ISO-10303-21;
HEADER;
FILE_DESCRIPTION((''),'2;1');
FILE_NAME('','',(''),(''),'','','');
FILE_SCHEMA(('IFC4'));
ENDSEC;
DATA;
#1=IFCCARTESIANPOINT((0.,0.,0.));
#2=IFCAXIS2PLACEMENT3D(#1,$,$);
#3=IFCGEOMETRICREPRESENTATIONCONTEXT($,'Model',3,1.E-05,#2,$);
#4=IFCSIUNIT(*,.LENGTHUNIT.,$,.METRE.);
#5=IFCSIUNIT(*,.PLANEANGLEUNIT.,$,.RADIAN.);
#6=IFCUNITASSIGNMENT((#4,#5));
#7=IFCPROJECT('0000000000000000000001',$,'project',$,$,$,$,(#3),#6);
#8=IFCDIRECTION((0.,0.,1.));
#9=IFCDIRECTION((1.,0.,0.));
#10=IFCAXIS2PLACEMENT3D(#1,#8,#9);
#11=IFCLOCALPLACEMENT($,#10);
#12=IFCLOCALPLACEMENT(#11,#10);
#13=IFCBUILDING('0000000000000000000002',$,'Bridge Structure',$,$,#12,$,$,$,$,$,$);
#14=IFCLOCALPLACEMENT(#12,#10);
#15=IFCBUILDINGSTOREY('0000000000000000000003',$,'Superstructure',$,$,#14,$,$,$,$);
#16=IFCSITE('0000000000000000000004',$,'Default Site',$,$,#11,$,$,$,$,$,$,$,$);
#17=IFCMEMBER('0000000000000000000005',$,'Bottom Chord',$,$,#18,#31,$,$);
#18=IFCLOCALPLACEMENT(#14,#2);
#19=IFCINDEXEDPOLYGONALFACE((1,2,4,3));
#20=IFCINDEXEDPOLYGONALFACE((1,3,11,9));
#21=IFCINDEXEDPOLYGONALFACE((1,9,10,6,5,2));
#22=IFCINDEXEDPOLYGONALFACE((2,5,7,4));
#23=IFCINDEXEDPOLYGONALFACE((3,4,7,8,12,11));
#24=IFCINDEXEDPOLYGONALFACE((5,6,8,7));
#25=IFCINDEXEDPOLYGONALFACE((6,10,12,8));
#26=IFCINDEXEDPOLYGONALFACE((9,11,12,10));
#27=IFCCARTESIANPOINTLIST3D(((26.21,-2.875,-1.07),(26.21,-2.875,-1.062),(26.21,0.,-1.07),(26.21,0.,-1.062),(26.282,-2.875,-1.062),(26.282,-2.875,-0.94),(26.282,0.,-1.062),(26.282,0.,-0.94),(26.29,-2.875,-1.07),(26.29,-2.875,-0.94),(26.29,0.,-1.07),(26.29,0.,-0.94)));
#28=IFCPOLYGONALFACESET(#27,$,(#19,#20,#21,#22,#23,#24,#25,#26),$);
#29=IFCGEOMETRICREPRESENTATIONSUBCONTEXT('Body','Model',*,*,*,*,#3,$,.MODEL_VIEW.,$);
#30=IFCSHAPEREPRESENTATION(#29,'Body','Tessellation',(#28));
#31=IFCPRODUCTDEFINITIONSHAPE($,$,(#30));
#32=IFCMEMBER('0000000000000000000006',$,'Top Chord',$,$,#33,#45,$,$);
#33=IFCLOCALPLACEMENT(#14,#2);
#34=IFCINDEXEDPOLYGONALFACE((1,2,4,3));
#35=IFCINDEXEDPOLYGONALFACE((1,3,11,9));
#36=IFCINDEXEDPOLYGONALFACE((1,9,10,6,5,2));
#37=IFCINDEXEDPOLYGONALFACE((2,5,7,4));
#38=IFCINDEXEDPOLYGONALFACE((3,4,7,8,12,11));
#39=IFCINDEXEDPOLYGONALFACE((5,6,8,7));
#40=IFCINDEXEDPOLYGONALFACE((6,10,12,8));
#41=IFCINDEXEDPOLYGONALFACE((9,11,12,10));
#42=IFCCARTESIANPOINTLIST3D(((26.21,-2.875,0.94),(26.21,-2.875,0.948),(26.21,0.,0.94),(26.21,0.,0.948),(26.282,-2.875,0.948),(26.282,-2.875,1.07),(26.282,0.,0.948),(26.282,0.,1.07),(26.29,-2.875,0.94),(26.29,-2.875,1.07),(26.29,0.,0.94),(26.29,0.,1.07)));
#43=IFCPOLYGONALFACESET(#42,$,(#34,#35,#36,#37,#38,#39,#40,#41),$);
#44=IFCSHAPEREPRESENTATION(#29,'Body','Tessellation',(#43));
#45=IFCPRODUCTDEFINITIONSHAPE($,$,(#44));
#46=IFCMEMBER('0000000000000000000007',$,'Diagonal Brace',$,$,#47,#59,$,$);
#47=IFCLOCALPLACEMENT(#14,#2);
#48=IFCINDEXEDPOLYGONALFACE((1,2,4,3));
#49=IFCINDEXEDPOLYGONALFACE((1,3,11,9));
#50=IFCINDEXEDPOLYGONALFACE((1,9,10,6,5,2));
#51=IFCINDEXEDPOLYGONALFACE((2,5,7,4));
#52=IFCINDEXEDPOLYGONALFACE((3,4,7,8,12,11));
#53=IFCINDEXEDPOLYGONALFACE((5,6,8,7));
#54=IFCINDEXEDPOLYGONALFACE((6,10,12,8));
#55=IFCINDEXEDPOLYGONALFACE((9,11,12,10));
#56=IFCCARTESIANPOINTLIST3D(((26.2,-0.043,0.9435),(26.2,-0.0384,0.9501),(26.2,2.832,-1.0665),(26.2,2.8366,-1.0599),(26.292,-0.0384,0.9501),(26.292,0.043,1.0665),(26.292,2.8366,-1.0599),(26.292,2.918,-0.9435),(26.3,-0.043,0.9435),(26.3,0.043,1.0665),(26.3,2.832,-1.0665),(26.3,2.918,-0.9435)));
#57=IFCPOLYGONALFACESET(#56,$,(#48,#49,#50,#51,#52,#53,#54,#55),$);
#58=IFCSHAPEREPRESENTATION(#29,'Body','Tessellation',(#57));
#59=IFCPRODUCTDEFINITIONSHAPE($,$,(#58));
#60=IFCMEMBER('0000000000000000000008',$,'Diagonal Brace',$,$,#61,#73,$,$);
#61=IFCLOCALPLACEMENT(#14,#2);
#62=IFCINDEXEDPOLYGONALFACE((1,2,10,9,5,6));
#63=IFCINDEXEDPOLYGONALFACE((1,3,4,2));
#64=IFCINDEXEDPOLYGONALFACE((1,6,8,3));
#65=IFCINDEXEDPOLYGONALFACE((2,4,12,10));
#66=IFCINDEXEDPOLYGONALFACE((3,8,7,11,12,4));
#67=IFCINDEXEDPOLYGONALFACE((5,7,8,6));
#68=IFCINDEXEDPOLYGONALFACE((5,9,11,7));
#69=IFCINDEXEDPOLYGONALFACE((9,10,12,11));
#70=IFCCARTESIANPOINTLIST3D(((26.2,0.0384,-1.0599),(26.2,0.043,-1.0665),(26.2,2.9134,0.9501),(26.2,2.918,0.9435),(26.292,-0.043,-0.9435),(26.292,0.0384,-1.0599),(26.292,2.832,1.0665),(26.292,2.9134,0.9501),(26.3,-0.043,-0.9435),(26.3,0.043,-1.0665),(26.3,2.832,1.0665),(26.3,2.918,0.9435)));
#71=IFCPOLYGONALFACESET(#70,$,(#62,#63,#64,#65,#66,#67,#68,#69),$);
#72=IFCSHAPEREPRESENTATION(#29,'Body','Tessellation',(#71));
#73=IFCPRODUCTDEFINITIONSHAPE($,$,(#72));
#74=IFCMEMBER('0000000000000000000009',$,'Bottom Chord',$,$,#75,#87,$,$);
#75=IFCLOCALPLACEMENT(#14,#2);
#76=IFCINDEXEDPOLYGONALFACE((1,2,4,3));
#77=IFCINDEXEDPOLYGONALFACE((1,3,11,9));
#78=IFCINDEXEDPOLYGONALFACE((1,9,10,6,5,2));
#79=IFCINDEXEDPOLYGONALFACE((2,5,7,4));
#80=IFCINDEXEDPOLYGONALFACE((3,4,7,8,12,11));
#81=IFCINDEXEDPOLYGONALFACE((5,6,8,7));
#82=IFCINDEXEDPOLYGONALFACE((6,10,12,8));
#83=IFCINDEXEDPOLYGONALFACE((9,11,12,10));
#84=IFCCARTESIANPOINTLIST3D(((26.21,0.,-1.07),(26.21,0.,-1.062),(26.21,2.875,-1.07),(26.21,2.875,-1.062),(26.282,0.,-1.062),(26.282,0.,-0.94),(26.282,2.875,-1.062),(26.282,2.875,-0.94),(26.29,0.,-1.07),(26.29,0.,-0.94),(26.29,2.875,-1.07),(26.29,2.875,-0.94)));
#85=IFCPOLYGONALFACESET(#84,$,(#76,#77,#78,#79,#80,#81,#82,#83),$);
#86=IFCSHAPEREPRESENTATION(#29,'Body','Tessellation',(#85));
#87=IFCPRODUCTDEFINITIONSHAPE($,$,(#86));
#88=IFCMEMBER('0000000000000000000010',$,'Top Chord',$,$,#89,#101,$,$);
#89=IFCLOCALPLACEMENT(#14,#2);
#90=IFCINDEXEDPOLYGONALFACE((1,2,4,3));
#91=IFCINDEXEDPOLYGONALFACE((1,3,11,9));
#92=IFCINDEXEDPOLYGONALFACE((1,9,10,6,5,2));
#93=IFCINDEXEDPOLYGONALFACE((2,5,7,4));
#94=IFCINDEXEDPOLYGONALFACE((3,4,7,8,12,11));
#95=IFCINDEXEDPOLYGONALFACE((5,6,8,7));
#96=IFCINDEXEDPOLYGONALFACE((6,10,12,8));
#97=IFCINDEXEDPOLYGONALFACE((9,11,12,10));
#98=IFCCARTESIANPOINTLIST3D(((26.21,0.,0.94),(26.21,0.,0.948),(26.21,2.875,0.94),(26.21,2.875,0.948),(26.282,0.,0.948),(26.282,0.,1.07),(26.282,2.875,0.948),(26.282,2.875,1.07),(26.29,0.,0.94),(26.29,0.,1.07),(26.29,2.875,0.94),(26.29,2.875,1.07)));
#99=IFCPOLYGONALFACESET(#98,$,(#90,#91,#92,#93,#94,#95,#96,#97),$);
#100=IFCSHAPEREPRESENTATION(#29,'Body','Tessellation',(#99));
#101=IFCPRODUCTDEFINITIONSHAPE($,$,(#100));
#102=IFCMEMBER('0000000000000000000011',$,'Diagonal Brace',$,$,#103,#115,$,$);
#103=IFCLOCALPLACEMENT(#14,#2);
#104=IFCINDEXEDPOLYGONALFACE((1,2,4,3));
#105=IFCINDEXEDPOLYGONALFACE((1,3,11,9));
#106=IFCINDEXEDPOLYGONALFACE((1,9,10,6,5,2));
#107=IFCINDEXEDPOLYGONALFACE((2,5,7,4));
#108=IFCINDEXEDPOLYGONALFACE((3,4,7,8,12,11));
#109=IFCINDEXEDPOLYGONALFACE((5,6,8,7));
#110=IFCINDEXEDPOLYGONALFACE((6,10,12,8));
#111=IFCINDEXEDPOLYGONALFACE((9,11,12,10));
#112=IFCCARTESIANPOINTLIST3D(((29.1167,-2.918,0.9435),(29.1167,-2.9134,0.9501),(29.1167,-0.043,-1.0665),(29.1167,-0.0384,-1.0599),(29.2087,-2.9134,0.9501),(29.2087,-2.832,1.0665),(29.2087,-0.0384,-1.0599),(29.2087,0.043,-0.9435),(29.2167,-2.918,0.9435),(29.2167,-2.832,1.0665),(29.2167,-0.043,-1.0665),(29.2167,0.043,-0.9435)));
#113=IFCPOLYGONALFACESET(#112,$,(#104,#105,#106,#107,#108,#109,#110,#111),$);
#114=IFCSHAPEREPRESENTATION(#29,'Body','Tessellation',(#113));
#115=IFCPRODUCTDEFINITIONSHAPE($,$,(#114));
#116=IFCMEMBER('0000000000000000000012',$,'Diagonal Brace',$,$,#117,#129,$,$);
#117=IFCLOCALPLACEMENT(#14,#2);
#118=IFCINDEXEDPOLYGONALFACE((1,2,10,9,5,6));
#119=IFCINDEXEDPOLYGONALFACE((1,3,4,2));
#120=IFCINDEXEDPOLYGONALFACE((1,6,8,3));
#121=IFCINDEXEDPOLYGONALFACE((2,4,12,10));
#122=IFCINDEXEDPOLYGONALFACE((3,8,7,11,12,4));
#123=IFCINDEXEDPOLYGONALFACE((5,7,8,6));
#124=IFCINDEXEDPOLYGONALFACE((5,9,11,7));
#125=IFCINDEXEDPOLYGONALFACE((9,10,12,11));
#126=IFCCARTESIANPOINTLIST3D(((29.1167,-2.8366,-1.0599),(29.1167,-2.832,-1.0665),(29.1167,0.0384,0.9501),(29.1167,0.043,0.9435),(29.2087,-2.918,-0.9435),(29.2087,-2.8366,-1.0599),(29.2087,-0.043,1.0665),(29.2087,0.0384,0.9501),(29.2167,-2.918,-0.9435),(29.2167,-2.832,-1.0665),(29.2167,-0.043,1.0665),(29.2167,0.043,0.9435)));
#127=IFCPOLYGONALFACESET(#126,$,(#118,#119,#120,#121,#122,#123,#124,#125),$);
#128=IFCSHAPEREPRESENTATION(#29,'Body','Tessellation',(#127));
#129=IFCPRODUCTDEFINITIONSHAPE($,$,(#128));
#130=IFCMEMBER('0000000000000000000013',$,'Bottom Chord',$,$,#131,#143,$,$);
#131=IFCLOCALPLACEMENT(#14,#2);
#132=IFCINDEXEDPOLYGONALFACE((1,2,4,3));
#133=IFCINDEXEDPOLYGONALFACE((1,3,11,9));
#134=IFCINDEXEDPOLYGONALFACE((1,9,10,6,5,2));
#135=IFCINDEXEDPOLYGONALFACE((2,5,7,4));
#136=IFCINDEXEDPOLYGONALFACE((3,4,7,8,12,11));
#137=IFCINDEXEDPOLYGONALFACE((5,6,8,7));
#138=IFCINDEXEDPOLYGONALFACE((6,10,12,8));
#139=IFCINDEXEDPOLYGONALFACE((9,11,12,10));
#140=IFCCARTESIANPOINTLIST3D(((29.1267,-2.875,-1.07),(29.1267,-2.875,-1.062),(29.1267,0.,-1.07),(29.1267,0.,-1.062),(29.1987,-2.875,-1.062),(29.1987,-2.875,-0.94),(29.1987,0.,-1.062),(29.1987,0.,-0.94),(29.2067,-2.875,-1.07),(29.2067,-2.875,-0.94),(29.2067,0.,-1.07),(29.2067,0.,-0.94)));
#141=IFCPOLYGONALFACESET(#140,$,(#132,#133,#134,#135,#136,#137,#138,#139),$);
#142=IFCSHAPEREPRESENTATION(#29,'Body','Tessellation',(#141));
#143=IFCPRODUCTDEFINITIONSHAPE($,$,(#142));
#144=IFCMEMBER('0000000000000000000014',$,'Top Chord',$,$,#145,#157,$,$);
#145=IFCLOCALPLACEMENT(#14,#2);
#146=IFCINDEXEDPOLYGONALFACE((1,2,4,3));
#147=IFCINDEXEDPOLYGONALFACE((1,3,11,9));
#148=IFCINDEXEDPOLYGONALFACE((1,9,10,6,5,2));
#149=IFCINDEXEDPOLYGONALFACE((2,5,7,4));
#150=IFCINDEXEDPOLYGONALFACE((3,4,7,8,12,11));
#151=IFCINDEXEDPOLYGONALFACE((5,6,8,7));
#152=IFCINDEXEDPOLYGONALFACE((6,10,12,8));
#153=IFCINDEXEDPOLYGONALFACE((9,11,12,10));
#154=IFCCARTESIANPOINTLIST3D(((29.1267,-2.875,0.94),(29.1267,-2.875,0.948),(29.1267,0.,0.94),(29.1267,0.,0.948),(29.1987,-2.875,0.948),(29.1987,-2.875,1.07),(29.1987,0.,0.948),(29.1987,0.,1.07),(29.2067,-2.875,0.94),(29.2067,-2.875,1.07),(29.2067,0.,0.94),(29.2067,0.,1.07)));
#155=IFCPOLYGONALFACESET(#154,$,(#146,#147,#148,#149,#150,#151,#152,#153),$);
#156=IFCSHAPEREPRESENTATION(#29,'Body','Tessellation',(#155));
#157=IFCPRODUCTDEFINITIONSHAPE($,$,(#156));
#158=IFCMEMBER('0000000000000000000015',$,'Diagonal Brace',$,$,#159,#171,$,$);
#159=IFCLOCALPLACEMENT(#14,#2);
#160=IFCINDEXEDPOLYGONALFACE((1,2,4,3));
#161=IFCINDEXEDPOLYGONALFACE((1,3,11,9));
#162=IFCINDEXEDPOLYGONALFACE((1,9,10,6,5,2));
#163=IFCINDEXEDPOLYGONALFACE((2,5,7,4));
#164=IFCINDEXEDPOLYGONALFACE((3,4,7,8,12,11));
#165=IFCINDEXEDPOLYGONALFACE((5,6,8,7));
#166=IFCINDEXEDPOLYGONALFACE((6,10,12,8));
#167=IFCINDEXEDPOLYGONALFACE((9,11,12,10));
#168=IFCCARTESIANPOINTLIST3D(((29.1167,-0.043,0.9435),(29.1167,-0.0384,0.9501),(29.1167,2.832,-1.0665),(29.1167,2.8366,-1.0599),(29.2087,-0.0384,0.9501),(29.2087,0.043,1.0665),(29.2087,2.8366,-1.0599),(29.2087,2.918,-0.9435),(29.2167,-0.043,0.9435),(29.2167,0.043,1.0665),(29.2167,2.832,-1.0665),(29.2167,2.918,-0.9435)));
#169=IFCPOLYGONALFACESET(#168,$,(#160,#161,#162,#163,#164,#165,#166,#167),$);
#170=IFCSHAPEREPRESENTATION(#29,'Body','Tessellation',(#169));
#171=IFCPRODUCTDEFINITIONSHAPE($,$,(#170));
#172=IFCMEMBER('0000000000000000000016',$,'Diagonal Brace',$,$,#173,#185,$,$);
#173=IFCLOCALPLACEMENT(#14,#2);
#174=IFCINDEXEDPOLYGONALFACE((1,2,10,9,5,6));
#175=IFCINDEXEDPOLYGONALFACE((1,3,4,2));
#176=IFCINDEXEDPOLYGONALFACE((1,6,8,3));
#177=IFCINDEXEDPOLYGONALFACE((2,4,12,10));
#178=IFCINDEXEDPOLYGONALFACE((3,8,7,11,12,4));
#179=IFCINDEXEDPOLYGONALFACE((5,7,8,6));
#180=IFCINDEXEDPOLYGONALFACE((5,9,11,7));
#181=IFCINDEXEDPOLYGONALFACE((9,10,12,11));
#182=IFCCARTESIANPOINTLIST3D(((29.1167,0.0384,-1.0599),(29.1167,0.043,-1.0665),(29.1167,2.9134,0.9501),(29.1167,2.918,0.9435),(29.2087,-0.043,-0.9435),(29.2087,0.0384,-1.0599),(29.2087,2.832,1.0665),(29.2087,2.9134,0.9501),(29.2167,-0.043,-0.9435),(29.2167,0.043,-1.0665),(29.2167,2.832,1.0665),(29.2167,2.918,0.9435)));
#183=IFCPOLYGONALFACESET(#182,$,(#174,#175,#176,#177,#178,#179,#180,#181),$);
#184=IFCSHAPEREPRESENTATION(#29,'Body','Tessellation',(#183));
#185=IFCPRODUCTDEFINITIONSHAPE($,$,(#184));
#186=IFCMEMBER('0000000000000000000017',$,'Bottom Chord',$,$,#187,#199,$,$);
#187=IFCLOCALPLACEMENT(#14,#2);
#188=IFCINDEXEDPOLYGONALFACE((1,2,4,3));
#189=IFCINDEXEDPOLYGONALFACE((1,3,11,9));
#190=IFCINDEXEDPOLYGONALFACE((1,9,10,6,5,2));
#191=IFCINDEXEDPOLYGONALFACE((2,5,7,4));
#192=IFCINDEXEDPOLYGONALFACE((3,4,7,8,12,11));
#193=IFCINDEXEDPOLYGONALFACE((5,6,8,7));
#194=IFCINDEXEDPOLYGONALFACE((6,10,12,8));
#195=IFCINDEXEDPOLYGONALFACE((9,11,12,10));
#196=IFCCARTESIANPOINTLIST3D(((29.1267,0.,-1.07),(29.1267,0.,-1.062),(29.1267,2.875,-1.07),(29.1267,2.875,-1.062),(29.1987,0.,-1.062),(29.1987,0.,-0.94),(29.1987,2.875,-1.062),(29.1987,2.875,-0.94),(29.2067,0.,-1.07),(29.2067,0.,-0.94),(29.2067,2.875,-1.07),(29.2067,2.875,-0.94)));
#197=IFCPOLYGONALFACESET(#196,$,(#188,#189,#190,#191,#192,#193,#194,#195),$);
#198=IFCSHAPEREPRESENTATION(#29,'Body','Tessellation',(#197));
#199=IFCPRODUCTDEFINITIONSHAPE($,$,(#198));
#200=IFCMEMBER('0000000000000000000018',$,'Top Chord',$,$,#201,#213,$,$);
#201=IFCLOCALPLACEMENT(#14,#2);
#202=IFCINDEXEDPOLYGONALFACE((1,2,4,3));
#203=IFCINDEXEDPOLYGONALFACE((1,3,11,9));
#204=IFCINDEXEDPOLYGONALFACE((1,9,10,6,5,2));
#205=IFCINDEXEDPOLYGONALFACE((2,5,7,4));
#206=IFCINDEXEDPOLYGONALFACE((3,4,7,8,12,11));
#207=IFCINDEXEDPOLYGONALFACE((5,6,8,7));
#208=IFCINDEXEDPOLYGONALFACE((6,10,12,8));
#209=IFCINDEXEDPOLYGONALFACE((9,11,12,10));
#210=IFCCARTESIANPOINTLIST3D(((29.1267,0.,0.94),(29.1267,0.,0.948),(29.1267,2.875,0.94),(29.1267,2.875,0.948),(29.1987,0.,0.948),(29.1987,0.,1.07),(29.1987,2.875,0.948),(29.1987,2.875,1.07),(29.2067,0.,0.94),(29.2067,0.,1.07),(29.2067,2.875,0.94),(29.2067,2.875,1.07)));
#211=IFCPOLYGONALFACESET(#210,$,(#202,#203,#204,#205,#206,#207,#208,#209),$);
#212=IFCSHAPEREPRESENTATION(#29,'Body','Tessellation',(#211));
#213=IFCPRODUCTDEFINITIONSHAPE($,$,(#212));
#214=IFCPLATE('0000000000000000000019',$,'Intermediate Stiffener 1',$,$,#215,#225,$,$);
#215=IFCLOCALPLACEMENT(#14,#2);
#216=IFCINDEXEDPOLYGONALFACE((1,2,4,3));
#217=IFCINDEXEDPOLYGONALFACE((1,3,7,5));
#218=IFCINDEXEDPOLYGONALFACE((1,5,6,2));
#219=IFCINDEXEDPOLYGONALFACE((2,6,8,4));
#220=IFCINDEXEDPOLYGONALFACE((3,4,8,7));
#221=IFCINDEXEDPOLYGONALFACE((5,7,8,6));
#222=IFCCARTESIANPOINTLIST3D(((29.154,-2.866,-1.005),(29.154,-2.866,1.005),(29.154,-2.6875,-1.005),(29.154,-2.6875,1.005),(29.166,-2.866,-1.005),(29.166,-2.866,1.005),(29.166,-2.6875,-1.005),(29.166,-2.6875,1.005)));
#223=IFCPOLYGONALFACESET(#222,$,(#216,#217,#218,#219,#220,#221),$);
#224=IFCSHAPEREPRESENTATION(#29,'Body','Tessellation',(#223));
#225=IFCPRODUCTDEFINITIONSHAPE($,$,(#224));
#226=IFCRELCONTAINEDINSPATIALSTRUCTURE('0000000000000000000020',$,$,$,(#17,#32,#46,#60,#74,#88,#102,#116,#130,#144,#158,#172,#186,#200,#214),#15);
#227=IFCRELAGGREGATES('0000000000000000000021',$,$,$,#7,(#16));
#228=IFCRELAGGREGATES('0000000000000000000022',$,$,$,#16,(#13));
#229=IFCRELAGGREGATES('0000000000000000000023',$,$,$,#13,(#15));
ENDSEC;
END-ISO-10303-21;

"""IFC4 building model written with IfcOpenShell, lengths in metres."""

from ifc_helpers import new_model, si_unit, frame, origin, origin_with_axes, origin_2d_with_axis, place, context, subcontext, project, spatial, rectangle, l_section, extrude, element, save


model = new_model("IFC4")

# Units and contexts
model_context = context("Model", 3, precision=1e-05, world=origin())
body_context = subcontext(model_context, "Body", "Model", "MODEL_VIEW")
ifc_project = project(units=[si_unit("LENGTHUNIT", "METRE"), si_unit("PLANEANGLEUNIT", "RADIAN")], contexts=[model_context])

# Site, building, storey
site_placement = place(None, origin_with_axes())
site = spatial("IfcSite", under=ifc_project, at=site_placement, Name="Default Site")
building_placement = place(site_placement, origin_with_axes())
building = spatial("IfcBuilding", under=site, at=building_placement, Name="Bridge Structure")
storey_placement = place(building_placement, origin_with_axes())
storey = spatial("IfcBuildingStorey", under=building, at=storey_placement, Name="Superstructure")

# Members
for number, where, z_axis, x_axis, name in (
    (1, (26.25, -2.875, -1.005), (0.0, 1.0, 0.0), (-1.0, 0.0, 0.0), "Bottom Chord"),
    (2, (26.25, -2.875, 1.005), (0.0, 1.0, 0.0), (-1.0, 0.0, 0.0), "Top Chord"),
):
    element("IfcMember", number, at=place(storey_placement, frame(where, z_axis=z_axis, x_axis=x_axis)), inside=storey, Name=name, context=body_context, shape_type="SweptSolid", body=[
        extrude(l_section(Depth=0.13, Width=0.08, Thickness=0.008, at=origin_2d_with_axis()), origin_with_axes(), (0.0, 0.0, 1.0), 2.875),
    ])
for number, where, z_axis, x_axis, name in (
    (3, (26.25, 0.0, 1.005), (0.0, 0.819567, -0.572984), (-1.0, 0.0, 0.0), "Diagonal Brace"),
    (4, (26.25, 0.0, -1.005), (0.0, 0.819567, 0.572984), (-1.0, 0.0, 0.0), "Diagonal Brace"),
):
    element("IfcMember", number, at=place(storey_placement, frame(where, z_axis=z_axis, x_axis=x_axis)), inside=storey, Name=name, context=body_context, shape_type="SweptSolid", body=[
        extrude(l_section(Depth=0.15, Width=0.1, Thickness=0.008, at=origin_2d_with_axis()), origin_with_axes(), (0.0, 0.0, 1.0), 3.508),
    ])
for number, where, z_axis, x_axis, name in (
    (5, (26.25, 0.0, -1.005), (0.0, 1.0, 0.0), (-1.0, 0.0, 0.0), "Bottom Chord"),
    (6, (26.25, 0.0, 1.005), (0.0, 1.0, 0.0), (-1.0, 0.0, 0.0), "Top Chord"),
):
    element("IfcMember", number, at=place(storey_placement, frame(where, z_axis=z_axis, x_axis=x_axis)), inside=storey, Name=name, context=body_context, shape_type="SweptSolid", body=[
        extrude(l_section(Depth=0.13, Width=0.08, Thickness=0.008, at=origin_2d_with_axis()), origin_with_axes(), (0.0, 0.0, 1.0), 2.875),
    ])
for number, where, z_axis, x_axis, name in (
    (7, (29.1667, -2.875, 1.005), (0.0, 0.819567, -0.572984), (-1.0, 0.0, 0.0), "Diagonal Brace"),
    (8, (29.1667, -2.875, -1.005), (0.0, 0.819567, 0.572984), (-1.0, 0.0, 0.0), "Diagonal Brace"),
):
    element("IfcMember", number, at=place(storey_placement, frame(where, z_axis=z_axis, x_axis=x_axis)), inside=storey, Name=name, context=body_context, shape_type="SweptSolid", body=[
        extrude(l_section(Depth=0.15, Width=0.1, Thickness=0.008, at=origin_2d_with_axis()), origin_with_axes(), (0.0, 0.0, 1.0), 3.508),
    ])
for number, where, z_axis, x_axis, name in (
    (9, (29.1667, -2.875, -1.005), (0.0, 1.0, 0.0), (-1.0, 0.0, 0.0), "Bottom Chord"),
    (10, (29.1667, -2.875, 1.005), (0.0, 1.0, 0.0), (-1.0, 0.0, 0.0), "Top Chord"),
):
    element("IfcMember", number, at=place(storey_placement, frame(where, z_axis=z_axis, x_axis=x_axis)), inside=storey, Name=name, context=body_context, shape_type="SweptSolid", body=[
        extrude(l_section(Depth=0.13, Width=0.08, Thickness=0.008, at=origin_2d_with_axis()), origin_with_axes(), (0.0, 0.0, 1.0), 2.875),
    ])
for number, where, z_axis, x_axis, name in (
    (11, (29.1667, 0.0, 1.005), (0.0, 0.819567, -0.572984), (-1.0, 0.0, 0.0), "Diagonal Brace"),
    (12, (29.1667, 0.0, -1.005), (0.0, 0.819567, 0.572984), (-1.0, 0.0, 0.0), "Diagonal Brace"),
):
    element("IfcMember", number, at=place(storey_placement, frame(where, z_axis=z_axis, x_axis=x_axis)), inside=storey, Name=name, context=body_context, shape_type="SweptSolid", body=[
        extrude(l_section(Depth=0.15, Width=0.1, Thickness=0.008, at=origin_2d_with_axis()), origin_with_axes(), (0.0, 0.0, 1.0), 3.508),
    ])
for number, where, z_axis, x_axis, name in (
    (13, (29.1667, 0.0, -1.005), (0.0, 1.0, 0.0), (-1.0, 0.0, 0.0), "Bottom Chord"),
    (14, (29.1667, 0.0, 1.005), (0.0, 1.0, 0.0), (-1.0, 0.0, 0.0), "Top Chord"),
):
    element("IfcMember", number, at=place(storey_placement, frame(where, z_axis=z_axis, x_axis=x_axis)), inside=storey, Name=name, context=body_context, shape_type="SweptSolid", body=[
        extrude(l_section(Depth=0.13, Width=0.08, Thickness=0.008, at=origin_2d_with_axis()), origin_with_axes(), (0.0, 0.0, 1.0), 2.875),
    ])

# Plate
for number, where, z_axis, x_axis, name in (
    (15, (29.16, -2.7768, -1.005), (0.0, 0.0, 1.0), (1.0, 0.0, 0.0), "Intermediate Stiffener 1"),
):
    element("IfcPlate", number, at=place(storey_placement, frame(where, z_axis=z_axis, x_axis=x_axis)), inside=storey, Name=name, context=body_context, shape_type="SweptSolid", body=[
        extrude(rectangle(XDim=0.012, YDim=0.1785, at=origin_2d_with_axis()), origin_with_axes(), (0.0, 0.0, 1.0), 2.01),
    ])

save(model, "model.ifc")
